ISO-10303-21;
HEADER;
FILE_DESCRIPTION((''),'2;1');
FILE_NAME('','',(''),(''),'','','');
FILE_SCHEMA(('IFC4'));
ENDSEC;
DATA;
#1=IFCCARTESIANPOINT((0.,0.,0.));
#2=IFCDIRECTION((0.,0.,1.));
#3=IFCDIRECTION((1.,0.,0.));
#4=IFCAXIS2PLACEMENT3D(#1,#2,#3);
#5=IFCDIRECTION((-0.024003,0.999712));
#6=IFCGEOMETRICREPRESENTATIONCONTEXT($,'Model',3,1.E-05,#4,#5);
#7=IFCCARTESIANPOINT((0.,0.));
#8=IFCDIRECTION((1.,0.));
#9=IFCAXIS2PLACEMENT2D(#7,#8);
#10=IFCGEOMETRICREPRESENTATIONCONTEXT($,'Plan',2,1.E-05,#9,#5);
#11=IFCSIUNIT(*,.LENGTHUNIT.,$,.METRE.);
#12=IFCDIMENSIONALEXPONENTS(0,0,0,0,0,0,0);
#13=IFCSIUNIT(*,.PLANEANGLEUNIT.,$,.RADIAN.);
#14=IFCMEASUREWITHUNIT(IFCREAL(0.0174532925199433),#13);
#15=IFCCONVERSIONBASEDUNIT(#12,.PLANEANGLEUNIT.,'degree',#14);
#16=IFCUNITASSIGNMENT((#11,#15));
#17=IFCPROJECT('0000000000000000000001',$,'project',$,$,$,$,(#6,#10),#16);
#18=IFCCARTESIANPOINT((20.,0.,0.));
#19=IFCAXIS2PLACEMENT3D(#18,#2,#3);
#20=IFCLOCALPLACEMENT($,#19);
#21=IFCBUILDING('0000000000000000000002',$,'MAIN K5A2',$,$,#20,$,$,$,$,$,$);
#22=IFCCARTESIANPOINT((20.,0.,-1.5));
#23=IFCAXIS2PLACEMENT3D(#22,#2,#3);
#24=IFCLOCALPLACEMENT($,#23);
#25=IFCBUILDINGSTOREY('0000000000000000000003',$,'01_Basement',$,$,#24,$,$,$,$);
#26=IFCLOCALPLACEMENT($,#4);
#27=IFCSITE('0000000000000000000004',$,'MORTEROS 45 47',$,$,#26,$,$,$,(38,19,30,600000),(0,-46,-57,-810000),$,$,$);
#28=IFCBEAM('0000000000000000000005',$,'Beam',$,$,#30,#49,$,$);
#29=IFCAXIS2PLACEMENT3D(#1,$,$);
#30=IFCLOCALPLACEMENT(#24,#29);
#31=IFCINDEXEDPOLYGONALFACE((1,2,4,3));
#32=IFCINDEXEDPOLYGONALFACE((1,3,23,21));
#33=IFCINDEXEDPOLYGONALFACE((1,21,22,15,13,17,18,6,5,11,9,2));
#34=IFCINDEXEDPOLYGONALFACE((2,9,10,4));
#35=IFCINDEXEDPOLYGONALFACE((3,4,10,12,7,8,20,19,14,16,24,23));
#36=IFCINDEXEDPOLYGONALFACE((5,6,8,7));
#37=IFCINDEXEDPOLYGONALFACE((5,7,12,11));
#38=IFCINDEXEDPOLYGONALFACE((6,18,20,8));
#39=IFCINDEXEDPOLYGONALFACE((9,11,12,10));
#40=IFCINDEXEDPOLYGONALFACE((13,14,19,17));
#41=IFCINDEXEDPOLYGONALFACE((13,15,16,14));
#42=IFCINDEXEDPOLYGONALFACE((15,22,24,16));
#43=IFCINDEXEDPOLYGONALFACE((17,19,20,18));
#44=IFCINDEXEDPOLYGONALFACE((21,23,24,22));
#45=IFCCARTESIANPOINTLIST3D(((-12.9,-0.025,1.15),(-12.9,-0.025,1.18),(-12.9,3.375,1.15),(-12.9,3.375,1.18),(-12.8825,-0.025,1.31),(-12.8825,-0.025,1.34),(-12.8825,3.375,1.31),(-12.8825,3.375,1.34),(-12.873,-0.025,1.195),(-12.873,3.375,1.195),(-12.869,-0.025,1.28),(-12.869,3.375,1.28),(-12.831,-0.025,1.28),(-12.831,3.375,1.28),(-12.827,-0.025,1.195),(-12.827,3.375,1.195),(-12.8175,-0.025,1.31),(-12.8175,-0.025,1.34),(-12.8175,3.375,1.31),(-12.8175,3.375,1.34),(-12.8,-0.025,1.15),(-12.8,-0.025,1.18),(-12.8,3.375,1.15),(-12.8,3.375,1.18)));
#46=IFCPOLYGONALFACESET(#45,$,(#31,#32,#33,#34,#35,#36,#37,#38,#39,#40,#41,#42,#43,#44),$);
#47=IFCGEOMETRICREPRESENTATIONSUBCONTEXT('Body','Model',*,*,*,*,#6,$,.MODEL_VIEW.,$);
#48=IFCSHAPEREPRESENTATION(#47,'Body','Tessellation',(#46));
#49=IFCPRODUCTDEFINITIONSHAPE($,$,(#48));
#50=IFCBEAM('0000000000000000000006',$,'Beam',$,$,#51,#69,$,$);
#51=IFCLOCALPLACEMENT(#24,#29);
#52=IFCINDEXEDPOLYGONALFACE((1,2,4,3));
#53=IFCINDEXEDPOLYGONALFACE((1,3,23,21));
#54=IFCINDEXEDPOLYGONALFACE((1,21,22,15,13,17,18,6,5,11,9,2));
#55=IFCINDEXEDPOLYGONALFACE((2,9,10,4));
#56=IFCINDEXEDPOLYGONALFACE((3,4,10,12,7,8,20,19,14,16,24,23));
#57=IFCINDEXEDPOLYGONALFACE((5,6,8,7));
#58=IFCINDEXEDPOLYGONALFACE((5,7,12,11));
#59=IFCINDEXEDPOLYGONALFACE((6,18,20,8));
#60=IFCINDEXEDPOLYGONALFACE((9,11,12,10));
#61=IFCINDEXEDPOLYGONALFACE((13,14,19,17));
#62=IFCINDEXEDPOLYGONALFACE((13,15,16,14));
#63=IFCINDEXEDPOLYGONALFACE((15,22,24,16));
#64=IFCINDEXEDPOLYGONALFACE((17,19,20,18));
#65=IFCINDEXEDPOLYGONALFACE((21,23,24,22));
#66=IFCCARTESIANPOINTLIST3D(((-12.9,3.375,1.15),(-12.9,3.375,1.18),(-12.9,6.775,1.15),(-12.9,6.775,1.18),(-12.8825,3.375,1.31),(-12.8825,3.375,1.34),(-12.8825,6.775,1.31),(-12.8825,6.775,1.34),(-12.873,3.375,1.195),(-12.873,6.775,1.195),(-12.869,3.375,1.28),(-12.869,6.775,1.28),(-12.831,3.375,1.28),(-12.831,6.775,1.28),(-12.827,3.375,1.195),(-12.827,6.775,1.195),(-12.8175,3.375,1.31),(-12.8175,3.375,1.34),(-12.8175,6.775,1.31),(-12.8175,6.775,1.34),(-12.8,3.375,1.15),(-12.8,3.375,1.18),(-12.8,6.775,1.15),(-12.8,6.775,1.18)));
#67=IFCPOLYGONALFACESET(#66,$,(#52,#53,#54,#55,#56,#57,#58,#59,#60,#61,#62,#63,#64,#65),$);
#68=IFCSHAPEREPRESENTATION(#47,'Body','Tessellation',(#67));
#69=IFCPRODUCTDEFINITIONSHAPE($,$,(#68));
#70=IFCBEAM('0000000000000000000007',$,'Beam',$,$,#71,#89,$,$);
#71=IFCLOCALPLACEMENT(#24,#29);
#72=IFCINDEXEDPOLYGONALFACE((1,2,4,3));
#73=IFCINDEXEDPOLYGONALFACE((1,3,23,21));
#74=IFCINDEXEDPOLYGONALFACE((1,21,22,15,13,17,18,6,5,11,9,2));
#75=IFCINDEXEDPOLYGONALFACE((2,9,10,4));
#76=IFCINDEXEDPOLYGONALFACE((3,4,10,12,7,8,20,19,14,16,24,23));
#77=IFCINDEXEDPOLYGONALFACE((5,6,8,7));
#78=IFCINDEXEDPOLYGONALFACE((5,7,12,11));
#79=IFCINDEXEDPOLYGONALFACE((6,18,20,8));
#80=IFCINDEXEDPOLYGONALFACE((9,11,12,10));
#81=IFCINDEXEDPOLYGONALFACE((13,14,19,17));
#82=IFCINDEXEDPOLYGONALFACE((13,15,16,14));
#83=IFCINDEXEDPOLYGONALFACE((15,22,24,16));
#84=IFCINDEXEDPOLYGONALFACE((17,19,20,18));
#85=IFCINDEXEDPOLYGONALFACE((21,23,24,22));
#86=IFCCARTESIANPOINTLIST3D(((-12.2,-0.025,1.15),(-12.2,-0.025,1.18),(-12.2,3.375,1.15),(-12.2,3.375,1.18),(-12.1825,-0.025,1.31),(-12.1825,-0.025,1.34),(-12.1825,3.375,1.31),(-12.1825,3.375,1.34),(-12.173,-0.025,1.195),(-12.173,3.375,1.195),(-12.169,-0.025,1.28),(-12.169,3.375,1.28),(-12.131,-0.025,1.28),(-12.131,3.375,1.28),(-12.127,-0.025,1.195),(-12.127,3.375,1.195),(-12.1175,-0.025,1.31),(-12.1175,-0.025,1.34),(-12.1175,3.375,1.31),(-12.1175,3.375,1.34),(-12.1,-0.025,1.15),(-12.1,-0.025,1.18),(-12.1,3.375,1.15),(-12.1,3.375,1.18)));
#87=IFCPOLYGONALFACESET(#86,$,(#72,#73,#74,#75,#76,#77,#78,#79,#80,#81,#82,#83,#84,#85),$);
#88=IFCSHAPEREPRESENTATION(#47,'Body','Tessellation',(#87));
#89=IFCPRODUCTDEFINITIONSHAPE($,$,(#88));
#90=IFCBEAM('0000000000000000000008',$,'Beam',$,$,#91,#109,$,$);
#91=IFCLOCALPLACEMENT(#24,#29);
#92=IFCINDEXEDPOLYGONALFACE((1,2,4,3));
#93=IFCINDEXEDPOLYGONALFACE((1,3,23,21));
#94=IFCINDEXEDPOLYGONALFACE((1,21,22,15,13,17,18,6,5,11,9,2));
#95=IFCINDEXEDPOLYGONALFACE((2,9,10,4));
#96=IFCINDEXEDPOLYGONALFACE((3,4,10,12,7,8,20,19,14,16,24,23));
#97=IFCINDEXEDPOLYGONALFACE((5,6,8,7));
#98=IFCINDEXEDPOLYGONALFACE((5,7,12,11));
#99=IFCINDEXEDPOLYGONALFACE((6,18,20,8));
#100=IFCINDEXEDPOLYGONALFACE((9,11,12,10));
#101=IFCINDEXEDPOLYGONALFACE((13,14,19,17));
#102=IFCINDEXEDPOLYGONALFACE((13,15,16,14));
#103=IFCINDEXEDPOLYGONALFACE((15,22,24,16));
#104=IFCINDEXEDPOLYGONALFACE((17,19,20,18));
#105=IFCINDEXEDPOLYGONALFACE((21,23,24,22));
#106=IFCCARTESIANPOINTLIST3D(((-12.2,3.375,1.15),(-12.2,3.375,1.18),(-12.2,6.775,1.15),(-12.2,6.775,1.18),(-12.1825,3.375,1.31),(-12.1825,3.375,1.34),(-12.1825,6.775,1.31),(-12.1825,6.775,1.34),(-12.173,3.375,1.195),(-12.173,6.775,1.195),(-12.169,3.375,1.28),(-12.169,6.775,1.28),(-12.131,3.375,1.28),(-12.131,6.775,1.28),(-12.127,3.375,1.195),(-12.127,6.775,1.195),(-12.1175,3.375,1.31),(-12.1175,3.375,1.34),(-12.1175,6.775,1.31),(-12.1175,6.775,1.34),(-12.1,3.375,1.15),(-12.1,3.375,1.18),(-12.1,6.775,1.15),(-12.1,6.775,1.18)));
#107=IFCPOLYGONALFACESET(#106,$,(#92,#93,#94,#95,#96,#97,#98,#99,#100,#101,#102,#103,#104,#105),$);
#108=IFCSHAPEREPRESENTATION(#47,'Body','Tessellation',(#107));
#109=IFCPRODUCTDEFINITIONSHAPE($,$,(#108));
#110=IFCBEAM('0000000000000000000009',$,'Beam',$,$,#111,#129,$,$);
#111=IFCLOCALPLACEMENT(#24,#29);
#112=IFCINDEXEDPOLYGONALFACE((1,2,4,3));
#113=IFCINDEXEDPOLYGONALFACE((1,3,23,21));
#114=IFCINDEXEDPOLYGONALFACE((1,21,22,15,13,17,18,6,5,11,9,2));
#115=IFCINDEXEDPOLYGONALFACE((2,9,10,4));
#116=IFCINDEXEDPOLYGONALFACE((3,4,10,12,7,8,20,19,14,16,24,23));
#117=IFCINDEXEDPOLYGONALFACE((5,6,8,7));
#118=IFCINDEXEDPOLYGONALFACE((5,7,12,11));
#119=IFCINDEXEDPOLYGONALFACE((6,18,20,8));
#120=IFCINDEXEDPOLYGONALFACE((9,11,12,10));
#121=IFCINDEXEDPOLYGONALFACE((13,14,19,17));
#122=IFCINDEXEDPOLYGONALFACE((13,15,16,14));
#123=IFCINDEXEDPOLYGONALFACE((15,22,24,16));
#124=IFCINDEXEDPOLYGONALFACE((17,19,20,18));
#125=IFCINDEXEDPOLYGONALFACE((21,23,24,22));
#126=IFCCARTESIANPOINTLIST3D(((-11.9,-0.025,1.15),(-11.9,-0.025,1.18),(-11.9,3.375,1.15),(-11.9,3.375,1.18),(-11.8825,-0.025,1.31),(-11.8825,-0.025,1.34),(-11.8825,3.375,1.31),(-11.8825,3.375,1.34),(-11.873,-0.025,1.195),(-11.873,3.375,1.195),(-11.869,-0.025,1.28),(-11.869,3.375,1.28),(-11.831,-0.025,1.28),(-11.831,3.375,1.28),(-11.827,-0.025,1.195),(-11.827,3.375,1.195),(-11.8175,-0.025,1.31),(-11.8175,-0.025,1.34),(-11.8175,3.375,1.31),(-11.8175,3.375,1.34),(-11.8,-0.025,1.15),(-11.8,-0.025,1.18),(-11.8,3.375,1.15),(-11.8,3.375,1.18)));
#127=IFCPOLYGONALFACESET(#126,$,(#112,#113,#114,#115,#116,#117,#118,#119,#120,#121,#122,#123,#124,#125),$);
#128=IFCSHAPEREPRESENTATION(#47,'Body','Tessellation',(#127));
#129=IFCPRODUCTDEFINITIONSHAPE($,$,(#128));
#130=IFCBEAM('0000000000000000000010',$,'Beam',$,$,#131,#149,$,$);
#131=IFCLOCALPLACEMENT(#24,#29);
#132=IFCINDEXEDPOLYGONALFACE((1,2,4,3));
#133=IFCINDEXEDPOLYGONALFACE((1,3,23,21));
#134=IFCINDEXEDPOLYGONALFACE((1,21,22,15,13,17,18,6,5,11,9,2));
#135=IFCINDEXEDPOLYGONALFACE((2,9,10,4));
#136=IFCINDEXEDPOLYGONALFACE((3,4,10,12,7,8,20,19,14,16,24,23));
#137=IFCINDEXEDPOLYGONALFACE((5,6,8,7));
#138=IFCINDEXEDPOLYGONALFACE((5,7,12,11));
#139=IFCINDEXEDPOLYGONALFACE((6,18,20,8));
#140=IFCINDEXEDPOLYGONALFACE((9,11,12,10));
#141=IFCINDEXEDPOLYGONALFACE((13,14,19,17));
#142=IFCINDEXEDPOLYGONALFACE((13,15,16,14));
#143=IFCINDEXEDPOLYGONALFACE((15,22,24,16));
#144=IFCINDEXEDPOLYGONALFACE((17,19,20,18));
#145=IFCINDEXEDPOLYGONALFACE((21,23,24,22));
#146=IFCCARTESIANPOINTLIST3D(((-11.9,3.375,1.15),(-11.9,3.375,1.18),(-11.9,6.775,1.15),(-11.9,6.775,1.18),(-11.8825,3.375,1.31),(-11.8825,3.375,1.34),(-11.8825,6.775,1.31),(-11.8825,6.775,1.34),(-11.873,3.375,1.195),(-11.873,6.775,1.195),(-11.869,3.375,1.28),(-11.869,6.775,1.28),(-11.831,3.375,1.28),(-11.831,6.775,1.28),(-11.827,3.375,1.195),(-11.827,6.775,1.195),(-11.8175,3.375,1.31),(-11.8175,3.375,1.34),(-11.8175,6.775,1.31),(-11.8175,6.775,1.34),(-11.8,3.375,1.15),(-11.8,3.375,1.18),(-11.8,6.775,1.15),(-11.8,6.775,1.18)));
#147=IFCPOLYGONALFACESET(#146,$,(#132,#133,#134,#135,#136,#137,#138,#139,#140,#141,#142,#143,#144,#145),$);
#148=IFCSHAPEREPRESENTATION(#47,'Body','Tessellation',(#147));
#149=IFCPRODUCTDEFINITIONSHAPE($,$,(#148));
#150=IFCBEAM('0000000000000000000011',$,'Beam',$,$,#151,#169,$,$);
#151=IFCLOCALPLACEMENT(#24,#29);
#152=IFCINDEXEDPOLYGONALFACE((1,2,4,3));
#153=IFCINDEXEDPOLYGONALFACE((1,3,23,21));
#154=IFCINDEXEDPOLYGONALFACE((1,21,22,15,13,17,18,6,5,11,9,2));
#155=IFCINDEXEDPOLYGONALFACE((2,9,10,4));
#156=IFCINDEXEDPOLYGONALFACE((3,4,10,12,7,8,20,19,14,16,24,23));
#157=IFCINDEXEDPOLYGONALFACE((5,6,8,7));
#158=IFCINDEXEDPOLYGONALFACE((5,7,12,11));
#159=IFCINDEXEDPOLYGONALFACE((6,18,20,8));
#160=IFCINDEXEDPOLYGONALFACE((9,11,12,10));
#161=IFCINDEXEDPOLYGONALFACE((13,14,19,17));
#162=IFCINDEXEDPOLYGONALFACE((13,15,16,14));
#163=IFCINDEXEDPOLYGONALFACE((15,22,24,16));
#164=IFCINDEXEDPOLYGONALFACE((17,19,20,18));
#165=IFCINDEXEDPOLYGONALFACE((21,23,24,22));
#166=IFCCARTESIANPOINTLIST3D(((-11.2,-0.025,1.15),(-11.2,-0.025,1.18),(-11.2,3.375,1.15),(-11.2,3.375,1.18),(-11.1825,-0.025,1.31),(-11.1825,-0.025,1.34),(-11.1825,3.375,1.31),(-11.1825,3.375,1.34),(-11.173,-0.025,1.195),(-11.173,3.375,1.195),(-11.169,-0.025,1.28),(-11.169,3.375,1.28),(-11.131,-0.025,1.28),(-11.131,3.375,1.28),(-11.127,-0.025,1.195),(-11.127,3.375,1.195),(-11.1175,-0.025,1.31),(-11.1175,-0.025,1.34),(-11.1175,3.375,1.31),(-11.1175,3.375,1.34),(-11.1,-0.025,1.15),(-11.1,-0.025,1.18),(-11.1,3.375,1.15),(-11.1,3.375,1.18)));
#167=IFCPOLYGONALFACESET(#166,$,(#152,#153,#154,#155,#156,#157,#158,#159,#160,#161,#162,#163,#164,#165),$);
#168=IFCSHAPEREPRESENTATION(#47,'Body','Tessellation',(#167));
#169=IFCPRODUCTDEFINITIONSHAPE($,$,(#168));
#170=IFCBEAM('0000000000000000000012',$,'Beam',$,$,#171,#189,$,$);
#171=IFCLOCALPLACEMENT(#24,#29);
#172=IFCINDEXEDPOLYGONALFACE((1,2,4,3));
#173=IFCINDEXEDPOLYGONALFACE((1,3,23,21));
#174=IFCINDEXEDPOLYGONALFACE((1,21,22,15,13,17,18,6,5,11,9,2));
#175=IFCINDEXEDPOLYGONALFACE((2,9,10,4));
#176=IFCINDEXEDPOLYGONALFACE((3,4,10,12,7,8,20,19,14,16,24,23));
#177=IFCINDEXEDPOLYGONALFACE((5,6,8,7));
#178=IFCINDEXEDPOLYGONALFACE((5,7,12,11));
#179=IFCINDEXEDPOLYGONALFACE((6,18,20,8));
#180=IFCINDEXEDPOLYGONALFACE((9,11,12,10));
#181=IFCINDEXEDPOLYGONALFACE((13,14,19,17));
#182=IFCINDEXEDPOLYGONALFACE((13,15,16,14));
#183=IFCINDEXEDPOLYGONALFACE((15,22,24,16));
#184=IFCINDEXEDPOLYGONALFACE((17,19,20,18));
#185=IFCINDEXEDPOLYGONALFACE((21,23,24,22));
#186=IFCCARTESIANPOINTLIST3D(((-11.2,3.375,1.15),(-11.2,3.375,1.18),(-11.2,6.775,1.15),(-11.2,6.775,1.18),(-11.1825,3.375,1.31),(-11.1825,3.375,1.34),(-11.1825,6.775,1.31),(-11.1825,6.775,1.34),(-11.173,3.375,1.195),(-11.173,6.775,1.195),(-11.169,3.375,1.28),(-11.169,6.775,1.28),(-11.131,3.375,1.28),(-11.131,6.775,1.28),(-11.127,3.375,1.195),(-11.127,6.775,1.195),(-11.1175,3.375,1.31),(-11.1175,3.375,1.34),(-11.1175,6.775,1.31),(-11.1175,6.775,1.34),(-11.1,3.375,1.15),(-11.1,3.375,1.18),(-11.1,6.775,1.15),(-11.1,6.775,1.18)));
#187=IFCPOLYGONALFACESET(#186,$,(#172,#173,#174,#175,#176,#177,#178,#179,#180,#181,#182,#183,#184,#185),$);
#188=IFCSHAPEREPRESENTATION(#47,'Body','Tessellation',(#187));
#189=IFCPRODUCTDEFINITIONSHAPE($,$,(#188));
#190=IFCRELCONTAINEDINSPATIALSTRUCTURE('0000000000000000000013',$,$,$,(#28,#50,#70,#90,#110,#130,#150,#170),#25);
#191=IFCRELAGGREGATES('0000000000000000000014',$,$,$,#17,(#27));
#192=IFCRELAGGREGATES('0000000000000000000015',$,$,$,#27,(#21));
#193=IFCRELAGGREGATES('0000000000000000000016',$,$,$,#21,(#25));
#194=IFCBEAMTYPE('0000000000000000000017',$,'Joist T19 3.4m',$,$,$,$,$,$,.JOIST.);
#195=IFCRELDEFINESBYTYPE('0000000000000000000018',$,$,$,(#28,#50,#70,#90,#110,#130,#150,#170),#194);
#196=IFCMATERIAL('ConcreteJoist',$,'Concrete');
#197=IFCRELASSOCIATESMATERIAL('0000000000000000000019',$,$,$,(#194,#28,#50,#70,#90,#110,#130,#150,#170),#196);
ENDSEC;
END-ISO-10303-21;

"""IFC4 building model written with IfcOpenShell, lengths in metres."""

from ifc_helpers import new_model, entity, si_unit, converted_unit, direction, frame, origin_with_axes, origin_2d_with_axis, place, context, subcontext, project, spatial, indexed_curve, outline, extrude, material, material_profile, profile_set, profile_usage, type_object, element, save


model = new_model("IFC4")

# Units and contexts
model_context = context("Model", 3, precision=1e-05, world=origin_with_axes(), true_north=direction((-0.024003, 0.999712)))
plan_context = context("Plan", 2, precision=1e-05, world=origin_2d_with_axis(), true_north=direction((-0.024003, 0.999712)))
body_context_1 = subcontext(model_context, "Body", "Model", "MODEL_VIEW")
ifc_project = project(units=[si_unit("LENGTHUNIT", "METRE"), converted_unit("PLANEANGLEUNIT", "degree", entity("IfcReal", 0.0174532925199433), si_unit("PLANEANGLEUNIT", "RADIAN"), dimensions=[0, 0, 0, 0, 0, 0, 0])], contexts=[model_context, plan_context])

# Site, building, storey
site_placement = place(None, origin_with_axes())
site = spatial("IfcSite", under=ifc_project, at=site_placement, Name="MORTEROS 45 47", RefLatitude=(38, 19, 30, 600000), RefLongitude=(0, -46, -57, -810000))
building_placement = place(None, frame((20.0, 0.0, 0.0), z_axis=(0.0, 0.0, 1.0), x_axis=(1.0, 0.0, 0.0)))
building = spatial("IfcBuilding", under=site, at=building_placement, Name="MAIN K5A2")
storey_placement = place(None, frame((20.0, 0.0, -1.5), z_axis=(0.0, 0.0, 1.0), x_axis=(1.0, 0.0, 0.0)))
storey = spatial("IfcBuildingStorey", under=building, at=storey_placement, Name="01_Basement")

# Beams
ifc_material = material(Name="ConcreteJoist", Category="Concrete")
ifc_material_profile = material_profile(ifc_material, outline(indexed_curve([(0.019, 0.13), (0.023, 0.045), (0.05, 0.03), (0.05, 0.0), (-0.05, 0.0), (-0.05, 0.03), (-0.023, 0.045), (-0.019, 0.13), (-0.0325, 0.16), (-0.0325, 0.19), (0.0325, 0.19), (0.0325, 0.16), (0.019, 0.13)])))
ifc_profile_set = profile_set([ifc_material_profile], Name="JoistMaterialProfileSet")
beam_type = type_object("IfcBeamType", Name="Joist T19 3.4m", PredefinedType="JOIST", material=ifc_profile_set)
ifc_profile_usage_1 = profile_usage(ifc_profile_set, cardinal=5)
beam_1_placement = place(None, frame((7.15, -0.025, -0.35), z_axis=(0.0, 1.0, 0.0), x_axis=(-1.0, 0.0, 0.0)))
element("IfcBeam", 1, at=beam_1_placement, inside=storey, type_object=beam_type, material=ifc_profile_usage_1, Name="Beam", context=body_context_1, shape_type="SweptSolid", body=[
    extrude(outline(indexed_curve([(0.019, 0.13), (0.023, 0.045), (0.05, 0.03), (0.05, 0.0), (-0.05, 0.0), (-0.05, 0.03), (-0.023, 0.045), (-0.019, 0.13), (-0.0325, 0.16), (-0.0325, 0.19), (0.0325, 0.19), (0.0325, 0.16), (0.019, 0.13)])), origin_with_axes(), (0.0, 0.0, 1.0), 3.4),
])
ifc_profile_usage_2 = profile_usage(ifc_profile_set, cardinal=5)
beam_2_placement = place(None, frame((7.15, 3.375, -0.35), z_axis=(0.0, 1.0, 0.0), x_axis=(-1.0, 0.0, 0.0)))
element("IfcBeam", 2, at=beam_2_placement, inside=storey, type_object=beam_type, material=ifc_profile_usage_2, Name="Beam", context=body_context_1, shape_type="SweptSolid", body=[
    extrude(outline(indexed_curve([(0.019, 0.13), (0.023, 0.045), (0.05, 0.03), (0.05, 0.0), (-0.05, 0.0), (-0.05, 0.03), (-0.023, 0.045), (-0.019, 0.13), (-0.0325, 0.16), (-0.0325, 0.19), (0.0325, 0.19), (0.0325, 0.16), (0.019, 0.13)])), origin_with_axes(), (0.0, 0.0, 1.0), 3.4),
])
ifc_profile_usage_3 = profile_usage(ifc_profile_set, cardinal=5)
beam_3_placement = place(None, frame((7.85, -0.025, -0.35), z_axis=(0.0, 1.0, 0.0), x_axis=(-1.0, 0.0, 0.0)))
element("IfcBeam", 3, at=beam_3_placement, inside=storey, type_object=beam_type, material=ifc_profile_usage_3, Name="Beam", context=body_context_1, shape_type="SweptSolid", body=[
    extrude(outline(indexed_curve([(0.019, 0.13), (0.023, 0.045), (0.05, 0.03), (0.05, 0.0), (-0.05, 0.0), (-0.05, 0.03), (-0.023, 0.045), (-0.019, 0.13), (-0.0325, 0.16), (-0.0325, 0.19), (0.0325, 0.19), (0.0325, 0.16), (0.019, 0.13)])), origin_with_axes(), (0.0, 0.0, 1.0), 3.4),
])
ifc_profile_usage_4 = profile_usage(ifc_profile_set, cardinal=5)
beam_4_placement = place(None, frame((7.85, 3.375, -0.35), z_axis=(0.0, 1.0, 0.0), x_axis=(-1.0, 0.0, 0.0)))
element("IfcBeam", 4, at=beam_4_placement, inside=storey, type_object=beam_type, material=ifc_profile_usage_4, Name="Beam", context=body_context_1, shape_type="SweptSolid", body=[
    extrude(outline(indexed_curve([(0.019, 0.13), (0.023, 0.045), (0.05, 0.03), (0.05, 0.0), (-0.05, 0.0), (-0.05, 0.03), (-0.023, 0.045), (-0.019, 0.13), (-0.0325, 0.16), (-0.0325, 0.19), (0.0325, 0.19), (0.0325, 0.16), (0.019, 0.13)])), origin_with_axes(), (0.0, 0.0, 1.0), 3.4),
])
ifc_profile_usage_5 = profile_usage(ifc_profile_set, cardinal=5)
beam_5_placement = place(None, frame((8.15, -0.025, -0.35), z_axis=(0.0, 1.0, 0.0), x_axis=(-1.0, 0.0, 0.0)))
element("IfcBeam", 5, at=beam_5_placement, inside=storey, type_object=beam_type, material=ifc_profile_usage_5, Name="Beam", context=body_context_1, shape_type="SweptSolid", body=[
    extrude(outline(indexed_curve([(0.019, 0.13), (0.023, 0.045), (0.05, 0.03), (0.05, 0.0), (-0.05, 0.0), (-0.05, 0.03), (-0.023, 0.045), (-0.019, 0.13), (-0.0325, 0.16), (-0.0325, 0.19), (0.0325, 0.19), (0.0325, 0.16), (0.019, 0.13)])), origin_with_axes(), (0.0, 0.0, 1.0), 3.4),
])
ifc_profile_usage_6 = profile_usage(ifc_profile_set, cardinal=5)
beam_6_placement = place(None, frame((8.15, 3.375, -0.35), z_axis=(0.0, 1.0, 0.0), x_axis=(-1.0, 0.0, 0.0)))
element("IfcBeam", 6, at=beam_6_placement, inside=storey, type_object=beam_type, material=ifc_profile_usage_6, Name="Beam", context=body_context_1, shape_type="SweptSolid", body=[
    extrude(outline(indexed_curve([(0.019, 0.13), (0.023, 0.045), (0.05, 0.03), (0.05, 0.0), (-0.05, 0.0), (-0.05, 0.03), (-0.023, 0.045), (-0.019, 0.13), (-0.0325, 0.16), (-0.0325, 0.19), (0.0325, 0.19), (0.0325, 0.16), (0.019, 0.13)])), origin_with_axes(), (0.0, 0.0, 1.0), 3.4),
])
ifc_profile_usage_7 = profile_usage(ifc_profile_set, cardinal=5)
beam_7_placement = place(None, frame((8.85, -0.025, -0.35), z_axis=(0.0, 1.0, 0.0), x_axis=(-1.0, 0.0, 0.0)))
element("IfcBeam", 7, at=beam_7_placement, inside=storey, type_object=beam_type, material=ifc_profile_usage_7, Name="Beam", context=body_context_1, shape_type="SweptSolid", body=[
    extrude(outline(indexed_curve([(0.019, 0.13), (0.023, 0.045), (0.05, 0.03), (0.05, 0.0), (-0.05, 0.0), (-0.05, 0.03), (-0.023, 0.045), (-0.019, 0.13), (-0.0325, 0.16), (-0.0325, 0.19), (0.0325, 0.19), (0.0325, 0.16), (0.019, 0.13)])), origin_with_axes(), (0.0, 0.0, 1.0), 3.4),
])
ifc_profile_usage_8 = profile_usage(ifc_profile_set, cardinal=5)
beam_8_placement = place(None, frame((8.85, 3.375, -0.35), z_axis=(0.0, 1.0, 0.0), x_axis=(-1.0, 0.0, 0.0)))
element("IfcBeam", 8, at=beam_8_placement, inside=storey, type_object=beam_type, material=ifc_profile_usage_8, Name="Beam", context=body_context_1, shape_type="SweptSolid", body=[
    extrude(outline(indexed_curve([(0.019, 0.13), (0.023, 0.045), (0.05, 0.03), (0.05, 0.0), (-0.05, 0.0), (-0.05, 0.03), (-0.023, 0.045), (-0.019, 0.13), (-0.0325, 0.16), (-0.0325, 0.19), (0.0325, 0.19), (0.0325, 0.16), (0.019, 0.13)])), origin_with_axes(), (0.0, 0.0, 1.0), 3.4),
])

save(model, "model.ifc")
